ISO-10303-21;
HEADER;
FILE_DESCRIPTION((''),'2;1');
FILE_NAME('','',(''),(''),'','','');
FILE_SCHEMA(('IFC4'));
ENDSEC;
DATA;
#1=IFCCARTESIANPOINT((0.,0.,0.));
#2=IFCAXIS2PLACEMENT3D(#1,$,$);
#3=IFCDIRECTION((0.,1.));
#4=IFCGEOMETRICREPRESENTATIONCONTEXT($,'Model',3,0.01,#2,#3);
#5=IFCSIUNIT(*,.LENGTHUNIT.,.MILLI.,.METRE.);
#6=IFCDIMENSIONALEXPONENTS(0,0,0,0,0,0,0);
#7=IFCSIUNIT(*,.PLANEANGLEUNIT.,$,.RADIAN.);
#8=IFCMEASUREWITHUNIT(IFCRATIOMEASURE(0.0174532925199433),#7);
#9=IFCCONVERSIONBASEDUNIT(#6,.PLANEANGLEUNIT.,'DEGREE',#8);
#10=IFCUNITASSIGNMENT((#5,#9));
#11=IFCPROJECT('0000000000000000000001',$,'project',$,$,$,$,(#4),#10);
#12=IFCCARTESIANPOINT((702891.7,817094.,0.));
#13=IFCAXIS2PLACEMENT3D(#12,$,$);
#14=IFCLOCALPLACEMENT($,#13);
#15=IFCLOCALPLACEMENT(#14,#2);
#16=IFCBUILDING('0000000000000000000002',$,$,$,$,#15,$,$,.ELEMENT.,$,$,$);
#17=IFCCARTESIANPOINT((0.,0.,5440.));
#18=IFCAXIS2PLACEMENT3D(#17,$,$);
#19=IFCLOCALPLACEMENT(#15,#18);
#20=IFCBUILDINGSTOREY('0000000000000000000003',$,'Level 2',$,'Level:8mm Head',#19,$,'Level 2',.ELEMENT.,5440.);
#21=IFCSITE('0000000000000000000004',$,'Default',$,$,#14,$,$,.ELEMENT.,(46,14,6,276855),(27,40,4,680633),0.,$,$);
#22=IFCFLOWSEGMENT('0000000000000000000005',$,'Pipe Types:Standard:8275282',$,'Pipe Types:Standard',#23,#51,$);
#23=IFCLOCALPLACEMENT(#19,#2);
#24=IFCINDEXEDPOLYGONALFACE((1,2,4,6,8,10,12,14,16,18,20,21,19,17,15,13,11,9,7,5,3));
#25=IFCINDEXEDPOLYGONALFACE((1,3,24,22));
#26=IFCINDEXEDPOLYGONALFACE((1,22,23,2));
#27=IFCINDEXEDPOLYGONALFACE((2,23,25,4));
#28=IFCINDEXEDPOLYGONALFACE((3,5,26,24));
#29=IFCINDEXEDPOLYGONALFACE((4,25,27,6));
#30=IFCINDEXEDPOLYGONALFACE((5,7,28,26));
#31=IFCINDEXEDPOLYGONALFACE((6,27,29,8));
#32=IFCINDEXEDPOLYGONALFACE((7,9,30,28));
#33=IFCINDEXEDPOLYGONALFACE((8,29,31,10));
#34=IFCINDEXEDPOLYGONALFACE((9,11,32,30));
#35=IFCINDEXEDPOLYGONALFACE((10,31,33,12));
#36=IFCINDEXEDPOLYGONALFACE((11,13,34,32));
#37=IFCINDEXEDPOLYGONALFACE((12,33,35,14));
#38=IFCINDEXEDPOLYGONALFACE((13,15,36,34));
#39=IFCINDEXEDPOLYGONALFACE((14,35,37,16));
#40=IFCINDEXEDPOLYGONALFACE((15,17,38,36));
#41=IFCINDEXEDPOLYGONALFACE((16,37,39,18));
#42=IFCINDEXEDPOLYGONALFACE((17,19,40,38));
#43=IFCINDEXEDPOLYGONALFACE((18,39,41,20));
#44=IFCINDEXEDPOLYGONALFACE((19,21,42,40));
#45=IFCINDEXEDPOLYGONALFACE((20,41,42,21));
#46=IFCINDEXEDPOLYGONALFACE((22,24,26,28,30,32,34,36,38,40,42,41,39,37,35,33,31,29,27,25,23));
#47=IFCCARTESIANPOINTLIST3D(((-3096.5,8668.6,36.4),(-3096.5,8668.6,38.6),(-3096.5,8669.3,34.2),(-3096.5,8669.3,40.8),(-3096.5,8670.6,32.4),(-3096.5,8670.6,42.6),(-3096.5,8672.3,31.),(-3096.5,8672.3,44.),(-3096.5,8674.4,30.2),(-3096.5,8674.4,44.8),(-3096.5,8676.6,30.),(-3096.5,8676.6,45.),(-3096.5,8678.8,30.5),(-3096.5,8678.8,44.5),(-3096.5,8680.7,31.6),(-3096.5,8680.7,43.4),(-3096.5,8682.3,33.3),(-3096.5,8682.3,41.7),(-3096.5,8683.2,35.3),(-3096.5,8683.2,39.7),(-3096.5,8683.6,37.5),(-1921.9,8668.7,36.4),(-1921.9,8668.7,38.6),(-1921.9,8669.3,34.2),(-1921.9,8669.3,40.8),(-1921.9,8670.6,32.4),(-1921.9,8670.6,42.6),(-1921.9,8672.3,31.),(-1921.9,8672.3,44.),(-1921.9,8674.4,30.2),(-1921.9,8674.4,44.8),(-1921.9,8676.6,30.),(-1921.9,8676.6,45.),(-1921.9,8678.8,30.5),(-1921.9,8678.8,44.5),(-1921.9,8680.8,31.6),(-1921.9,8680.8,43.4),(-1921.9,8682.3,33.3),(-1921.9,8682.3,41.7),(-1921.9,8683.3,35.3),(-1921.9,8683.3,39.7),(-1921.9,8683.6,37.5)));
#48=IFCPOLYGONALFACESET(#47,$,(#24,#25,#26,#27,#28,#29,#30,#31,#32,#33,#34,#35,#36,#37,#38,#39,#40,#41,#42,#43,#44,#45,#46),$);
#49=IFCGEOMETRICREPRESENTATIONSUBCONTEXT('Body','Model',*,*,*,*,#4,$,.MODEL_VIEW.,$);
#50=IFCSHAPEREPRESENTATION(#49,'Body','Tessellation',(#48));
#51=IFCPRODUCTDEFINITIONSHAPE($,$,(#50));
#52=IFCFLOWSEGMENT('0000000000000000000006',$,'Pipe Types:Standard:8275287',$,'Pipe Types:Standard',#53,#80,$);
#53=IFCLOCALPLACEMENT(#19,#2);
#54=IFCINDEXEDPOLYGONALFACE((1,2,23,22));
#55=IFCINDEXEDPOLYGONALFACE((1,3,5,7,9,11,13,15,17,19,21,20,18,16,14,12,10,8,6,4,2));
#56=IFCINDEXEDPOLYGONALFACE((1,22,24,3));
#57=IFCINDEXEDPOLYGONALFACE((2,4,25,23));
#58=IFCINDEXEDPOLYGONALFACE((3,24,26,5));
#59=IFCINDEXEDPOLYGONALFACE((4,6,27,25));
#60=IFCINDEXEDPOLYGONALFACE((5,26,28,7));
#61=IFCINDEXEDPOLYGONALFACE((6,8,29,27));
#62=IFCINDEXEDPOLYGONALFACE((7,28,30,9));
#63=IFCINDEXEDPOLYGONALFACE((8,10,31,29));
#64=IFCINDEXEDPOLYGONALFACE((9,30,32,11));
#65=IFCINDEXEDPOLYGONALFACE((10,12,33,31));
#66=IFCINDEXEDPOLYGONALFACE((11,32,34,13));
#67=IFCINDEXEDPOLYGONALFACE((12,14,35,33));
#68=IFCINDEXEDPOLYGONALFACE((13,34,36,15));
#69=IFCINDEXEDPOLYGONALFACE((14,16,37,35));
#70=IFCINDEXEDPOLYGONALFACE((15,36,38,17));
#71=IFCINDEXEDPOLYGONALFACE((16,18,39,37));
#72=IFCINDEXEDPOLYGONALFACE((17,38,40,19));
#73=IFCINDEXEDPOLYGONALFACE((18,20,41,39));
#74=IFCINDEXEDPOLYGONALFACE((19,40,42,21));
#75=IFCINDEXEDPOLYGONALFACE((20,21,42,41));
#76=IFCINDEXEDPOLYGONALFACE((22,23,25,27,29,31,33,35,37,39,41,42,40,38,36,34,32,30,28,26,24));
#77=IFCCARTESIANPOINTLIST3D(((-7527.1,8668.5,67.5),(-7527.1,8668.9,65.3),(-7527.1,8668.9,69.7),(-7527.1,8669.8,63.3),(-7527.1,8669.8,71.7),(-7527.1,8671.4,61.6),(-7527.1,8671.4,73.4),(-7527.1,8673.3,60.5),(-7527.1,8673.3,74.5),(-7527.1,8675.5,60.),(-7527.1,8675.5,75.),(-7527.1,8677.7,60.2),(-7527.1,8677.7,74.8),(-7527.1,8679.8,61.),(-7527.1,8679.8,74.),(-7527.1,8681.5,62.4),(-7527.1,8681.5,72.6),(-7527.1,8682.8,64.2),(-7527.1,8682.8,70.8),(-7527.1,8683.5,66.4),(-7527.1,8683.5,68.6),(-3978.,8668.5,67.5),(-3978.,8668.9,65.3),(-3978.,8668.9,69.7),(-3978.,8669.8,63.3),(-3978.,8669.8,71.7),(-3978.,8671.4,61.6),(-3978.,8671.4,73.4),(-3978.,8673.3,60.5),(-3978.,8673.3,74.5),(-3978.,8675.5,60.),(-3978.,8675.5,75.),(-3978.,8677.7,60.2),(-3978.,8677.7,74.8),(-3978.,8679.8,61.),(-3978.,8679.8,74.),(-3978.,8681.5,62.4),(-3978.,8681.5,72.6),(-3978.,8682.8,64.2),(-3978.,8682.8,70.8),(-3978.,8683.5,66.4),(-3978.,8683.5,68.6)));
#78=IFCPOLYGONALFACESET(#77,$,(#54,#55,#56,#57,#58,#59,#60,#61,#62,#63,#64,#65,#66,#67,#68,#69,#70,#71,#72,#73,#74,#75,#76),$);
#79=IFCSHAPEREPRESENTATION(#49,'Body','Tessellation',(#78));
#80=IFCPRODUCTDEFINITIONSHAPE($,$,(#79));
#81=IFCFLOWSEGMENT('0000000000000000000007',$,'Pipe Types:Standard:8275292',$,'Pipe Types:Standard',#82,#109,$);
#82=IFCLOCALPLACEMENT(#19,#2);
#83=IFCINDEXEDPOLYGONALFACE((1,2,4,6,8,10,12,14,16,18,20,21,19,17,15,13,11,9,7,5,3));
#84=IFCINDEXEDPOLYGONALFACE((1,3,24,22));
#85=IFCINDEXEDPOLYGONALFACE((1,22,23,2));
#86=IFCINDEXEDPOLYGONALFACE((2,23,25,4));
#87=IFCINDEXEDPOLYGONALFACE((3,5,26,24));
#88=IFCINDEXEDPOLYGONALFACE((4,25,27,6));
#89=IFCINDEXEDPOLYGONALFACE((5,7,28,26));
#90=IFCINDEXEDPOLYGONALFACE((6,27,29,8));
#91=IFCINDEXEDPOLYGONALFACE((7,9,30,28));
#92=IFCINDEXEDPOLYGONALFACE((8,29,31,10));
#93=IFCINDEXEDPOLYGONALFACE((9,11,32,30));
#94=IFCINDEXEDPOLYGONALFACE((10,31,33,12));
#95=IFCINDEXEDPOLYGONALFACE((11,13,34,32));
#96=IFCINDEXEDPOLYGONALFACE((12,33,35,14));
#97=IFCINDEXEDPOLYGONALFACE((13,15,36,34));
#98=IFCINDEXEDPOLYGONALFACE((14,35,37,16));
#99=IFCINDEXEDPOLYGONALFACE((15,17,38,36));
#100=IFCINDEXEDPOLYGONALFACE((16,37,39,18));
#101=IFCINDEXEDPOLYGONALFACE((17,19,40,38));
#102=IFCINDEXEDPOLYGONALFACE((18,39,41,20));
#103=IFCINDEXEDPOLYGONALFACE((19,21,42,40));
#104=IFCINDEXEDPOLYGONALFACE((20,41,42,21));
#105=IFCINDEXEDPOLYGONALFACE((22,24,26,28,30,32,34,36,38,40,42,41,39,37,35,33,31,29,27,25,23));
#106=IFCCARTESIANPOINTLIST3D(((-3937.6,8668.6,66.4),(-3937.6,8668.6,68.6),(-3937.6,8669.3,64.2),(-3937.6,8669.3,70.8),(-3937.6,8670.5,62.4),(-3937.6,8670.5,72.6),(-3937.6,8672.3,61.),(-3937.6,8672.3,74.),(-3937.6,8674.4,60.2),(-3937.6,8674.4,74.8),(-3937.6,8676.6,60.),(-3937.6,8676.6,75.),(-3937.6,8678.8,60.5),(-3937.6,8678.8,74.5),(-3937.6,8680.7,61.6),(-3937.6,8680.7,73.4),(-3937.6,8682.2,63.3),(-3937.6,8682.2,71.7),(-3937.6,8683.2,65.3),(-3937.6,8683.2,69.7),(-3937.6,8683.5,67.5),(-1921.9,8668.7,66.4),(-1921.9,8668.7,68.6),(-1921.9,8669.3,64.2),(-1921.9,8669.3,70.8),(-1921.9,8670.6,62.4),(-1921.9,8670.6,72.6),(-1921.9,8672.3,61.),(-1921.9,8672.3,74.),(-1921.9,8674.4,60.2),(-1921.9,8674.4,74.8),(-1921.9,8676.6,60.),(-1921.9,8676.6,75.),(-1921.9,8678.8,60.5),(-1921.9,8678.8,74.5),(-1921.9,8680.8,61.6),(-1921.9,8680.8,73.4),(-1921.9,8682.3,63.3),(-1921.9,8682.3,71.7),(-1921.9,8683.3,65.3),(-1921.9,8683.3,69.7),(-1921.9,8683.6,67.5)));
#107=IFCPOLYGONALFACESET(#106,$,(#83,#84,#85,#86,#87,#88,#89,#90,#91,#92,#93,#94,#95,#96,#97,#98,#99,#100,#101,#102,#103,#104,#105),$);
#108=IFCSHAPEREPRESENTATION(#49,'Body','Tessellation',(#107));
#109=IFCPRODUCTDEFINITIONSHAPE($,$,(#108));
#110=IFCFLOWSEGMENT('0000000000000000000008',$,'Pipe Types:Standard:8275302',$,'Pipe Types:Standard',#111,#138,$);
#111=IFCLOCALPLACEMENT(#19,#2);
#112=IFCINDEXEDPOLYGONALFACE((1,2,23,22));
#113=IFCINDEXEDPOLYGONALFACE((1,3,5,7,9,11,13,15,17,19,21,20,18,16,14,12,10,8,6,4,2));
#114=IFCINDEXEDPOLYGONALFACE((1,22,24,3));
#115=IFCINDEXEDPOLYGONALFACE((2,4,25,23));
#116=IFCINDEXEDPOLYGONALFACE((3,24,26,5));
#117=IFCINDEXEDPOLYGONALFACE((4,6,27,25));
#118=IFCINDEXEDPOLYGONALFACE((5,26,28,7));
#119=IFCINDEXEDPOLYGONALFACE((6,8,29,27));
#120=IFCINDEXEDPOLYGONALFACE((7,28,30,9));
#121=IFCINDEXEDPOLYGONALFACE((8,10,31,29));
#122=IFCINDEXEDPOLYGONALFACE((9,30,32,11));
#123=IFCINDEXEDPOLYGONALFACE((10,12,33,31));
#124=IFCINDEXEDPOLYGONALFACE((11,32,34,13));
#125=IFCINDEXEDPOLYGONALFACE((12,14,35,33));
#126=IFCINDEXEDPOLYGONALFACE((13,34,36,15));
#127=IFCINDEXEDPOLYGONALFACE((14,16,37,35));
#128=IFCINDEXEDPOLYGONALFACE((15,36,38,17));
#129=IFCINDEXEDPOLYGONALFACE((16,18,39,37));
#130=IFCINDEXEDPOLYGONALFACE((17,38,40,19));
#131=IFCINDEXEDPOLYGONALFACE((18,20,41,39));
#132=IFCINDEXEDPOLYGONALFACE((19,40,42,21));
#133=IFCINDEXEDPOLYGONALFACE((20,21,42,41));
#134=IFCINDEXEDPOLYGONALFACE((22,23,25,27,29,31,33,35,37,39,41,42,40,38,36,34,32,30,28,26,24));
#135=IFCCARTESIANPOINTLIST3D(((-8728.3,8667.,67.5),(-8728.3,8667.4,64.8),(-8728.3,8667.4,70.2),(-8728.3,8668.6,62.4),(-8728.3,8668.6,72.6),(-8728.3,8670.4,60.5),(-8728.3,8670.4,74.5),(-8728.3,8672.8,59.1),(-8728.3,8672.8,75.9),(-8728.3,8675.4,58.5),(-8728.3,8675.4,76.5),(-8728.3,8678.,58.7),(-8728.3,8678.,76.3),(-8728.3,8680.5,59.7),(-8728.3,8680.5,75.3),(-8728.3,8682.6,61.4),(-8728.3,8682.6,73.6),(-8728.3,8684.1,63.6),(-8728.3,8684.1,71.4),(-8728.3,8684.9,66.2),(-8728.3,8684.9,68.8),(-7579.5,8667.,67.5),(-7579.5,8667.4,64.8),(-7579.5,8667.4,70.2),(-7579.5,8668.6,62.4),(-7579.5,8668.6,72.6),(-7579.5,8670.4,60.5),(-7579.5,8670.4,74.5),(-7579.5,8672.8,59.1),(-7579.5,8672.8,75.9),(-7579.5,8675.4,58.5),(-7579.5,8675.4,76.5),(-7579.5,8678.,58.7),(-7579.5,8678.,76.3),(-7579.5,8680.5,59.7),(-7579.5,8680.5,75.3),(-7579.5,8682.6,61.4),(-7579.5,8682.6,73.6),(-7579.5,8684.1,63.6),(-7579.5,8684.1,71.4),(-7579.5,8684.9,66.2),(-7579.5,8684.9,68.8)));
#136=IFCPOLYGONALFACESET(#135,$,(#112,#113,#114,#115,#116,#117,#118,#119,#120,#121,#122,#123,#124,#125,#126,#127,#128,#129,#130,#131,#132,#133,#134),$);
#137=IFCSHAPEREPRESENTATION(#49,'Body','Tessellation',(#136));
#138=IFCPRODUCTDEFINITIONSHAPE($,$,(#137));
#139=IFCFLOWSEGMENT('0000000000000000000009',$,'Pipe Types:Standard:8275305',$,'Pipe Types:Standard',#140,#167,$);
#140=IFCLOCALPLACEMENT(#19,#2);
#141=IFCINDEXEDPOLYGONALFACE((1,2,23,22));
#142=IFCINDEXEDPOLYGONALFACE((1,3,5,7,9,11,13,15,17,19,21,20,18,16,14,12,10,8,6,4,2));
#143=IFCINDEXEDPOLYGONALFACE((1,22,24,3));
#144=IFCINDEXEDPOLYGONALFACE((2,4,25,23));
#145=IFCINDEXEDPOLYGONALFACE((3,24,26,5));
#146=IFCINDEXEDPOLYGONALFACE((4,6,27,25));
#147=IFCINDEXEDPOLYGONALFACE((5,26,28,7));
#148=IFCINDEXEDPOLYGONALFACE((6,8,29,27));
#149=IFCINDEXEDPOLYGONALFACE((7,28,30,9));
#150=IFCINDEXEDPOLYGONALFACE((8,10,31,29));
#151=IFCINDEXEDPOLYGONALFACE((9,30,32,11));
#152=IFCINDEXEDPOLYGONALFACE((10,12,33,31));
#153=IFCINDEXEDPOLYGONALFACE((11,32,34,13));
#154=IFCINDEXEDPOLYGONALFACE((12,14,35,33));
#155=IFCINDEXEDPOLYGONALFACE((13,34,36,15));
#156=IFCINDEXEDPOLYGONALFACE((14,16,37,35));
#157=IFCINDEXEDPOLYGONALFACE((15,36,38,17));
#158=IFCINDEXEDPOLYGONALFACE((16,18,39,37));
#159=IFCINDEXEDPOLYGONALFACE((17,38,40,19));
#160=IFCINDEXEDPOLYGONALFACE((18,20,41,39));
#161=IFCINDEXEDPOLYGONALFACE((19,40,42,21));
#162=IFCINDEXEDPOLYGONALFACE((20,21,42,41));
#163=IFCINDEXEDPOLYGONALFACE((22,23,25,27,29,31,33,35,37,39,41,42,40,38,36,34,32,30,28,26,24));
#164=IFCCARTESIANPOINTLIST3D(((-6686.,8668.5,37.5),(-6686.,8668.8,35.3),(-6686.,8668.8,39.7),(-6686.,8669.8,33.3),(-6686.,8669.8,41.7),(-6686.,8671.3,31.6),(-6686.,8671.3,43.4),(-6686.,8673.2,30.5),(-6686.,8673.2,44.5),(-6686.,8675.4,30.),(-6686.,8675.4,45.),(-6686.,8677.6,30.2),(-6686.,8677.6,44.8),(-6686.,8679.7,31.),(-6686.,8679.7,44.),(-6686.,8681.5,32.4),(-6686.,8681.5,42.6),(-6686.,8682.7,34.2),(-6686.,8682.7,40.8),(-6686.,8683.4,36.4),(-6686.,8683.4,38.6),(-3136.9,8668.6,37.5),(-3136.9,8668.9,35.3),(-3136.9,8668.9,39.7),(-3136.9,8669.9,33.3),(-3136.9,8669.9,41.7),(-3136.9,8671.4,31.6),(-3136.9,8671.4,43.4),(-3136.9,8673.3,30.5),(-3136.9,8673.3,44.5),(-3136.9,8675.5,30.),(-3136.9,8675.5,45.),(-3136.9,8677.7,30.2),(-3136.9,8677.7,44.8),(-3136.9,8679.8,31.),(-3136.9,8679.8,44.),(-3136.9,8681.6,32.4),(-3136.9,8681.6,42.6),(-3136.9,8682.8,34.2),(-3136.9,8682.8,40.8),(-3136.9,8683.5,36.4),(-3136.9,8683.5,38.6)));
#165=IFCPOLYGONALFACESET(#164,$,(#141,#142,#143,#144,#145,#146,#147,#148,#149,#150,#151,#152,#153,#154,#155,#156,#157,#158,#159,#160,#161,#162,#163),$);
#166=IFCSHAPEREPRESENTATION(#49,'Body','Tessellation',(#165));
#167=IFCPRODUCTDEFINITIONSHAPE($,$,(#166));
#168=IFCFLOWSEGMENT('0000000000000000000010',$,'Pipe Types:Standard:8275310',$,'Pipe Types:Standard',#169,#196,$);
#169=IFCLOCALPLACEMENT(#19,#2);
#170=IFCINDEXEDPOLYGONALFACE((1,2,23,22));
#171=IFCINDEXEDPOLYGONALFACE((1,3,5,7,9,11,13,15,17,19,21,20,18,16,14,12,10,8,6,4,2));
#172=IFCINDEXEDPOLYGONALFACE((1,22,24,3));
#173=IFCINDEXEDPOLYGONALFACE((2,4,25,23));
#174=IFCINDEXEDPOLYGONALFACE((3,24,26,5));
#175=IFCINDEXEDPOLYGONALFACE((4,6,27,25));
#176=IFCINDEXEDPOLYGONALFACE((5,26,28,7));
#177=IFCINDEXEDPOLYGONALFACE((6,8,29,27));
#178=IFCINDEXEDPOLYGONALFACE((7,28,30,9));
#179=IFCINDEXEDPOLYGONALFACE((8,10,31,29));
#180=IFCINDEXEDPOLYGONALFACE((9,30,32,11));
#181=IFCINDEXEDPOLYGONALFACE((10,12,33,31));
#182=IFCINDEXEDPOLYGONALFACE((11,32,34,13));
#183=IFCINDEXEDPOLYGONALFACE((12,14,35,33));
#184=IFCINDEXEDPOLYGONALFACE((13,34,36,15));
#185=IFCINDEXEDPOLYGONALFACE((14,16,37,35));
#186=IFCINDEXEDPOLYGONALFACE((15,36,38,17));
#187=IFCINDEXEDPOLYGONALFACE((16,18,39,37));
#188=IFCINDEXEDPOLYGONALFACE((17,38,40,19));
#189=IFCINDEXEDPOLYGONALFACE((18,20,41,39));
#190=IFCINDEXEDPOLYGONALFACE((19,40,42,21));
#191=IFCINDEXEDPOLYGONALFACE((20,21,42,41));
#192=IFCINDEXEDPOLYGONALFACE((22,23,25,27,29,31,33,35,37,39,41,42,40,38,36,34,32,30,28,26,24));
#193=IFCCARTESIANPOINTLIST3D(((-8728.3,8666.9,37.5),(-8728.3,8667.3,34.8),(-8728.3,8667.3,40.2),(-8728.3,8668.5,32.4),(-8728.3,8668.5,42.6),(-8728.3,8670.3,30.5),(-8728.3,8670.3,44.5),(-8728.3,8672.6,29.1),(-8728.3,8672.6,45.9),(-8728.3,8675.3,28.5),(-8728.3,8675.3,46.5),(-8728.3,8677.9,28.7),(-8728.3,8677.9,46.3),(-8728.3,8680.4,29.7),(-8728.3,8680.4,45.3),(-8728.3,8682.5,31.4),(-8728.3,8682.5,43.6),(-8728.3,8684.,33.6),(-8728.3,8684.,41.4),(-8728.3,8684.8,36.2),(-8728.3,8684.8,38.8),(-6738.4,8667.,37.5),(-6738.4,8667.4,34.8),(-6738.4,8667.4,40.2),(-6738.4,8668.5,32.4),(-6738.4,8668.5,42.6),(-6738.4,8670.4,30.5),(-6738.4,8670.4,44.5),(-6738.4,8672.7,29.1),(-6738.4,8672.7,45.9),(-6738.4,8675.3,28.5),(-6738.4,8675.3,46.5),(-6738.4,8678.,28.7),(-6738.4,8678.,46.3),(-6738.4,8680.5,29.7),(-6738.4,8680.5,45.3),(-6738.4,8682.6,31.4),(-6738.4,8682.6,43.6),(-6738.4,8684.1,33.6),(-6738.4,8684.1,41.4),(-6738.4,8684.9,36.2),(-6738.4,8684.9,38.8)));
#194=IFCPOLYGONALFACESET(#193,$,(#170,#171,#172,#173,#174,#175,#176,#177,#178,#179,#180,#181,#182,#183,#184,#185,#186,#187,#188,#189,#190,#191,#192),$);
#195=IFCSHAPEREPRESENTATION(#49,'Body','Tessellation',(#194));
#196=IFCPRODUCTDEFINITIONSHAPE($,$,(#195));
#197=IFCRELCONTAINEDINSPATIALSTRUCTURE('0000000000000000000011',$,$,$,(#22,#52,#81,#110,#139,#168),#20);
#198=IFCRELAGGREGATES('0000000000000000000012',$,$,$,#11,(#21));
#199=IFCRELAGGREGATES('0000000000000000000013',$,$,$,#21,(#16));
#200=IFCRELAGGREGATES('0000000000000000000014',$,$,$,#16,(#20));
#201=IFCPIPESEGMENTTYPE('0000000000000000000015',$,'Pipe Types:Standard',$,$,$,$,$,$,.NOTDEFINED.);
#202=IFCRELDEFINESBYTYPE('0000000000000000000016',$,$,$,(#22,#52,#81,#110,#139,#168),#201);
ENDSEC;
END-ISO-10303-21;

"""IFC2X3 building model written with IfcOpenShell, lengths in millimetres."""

from ifc_helpers import new_model, entity, si_unit, converted_unit, direction, frame, origin, origin_2d_with_axis, place, context, subcontext, project, spatial, circle, extrude, type_object, element, save


model = new_model("IFC2X3")

# Units and contexts
model_context = context("Model", 3, precision=0.01, world=origin(), true_north=direction((0.0, 1.0)))
body_context = subcontext(model_context, "Body", "Model", "MODEL_VIEW")
ifc_project = project(units=[si_unit("LENGTHUNIT", "METRE", prefix="MILLI"), converted_unit("PLANEANGLEUNIT", "DEGREE", entity("IfcRatioMeasure", 0.0174532925199433), si_unit("PLANEANGLEUNIT", "RADIAN"), dimensions=[0, 0, 0, 0, 0, 0, 0])], contexts=[model_context])

# Site, building, storey
site_placement = place(None, frame((702891.7, 817094.0, 0.0)))
site = spatial("IfcSite", under=ifc_project, at=site_placement, Name="Default", CompositionType="ELEMENT", RefLatitude=(46, 14, 6, 276855), RefLongitude=(27, 40, 4, 680633), RefElevation=0.0)
building_placement = place(site_placement, origin())
building = spatial("IfcBuilding", under=site, at=building_placement, CompositionType="ELEMENT")
storey_placement = place(building_placement, frame((0.0, 0.0, 5440.0)))
storey = spatial("IfcBuildingStorey", under=building, at=storey_placement, Name="Level 2", ObjectType="Level:8mm Head", LongName="Level 2", CompositionType="ELEMENT", Elevation=5440.0)

# Flow segments
pipe_segment_type = type_object("IfcPipeSegmentType", Name="Pipe Types:Standard", PredefinedType="NOTDEFINED")
flow_segment_1_placement = place(storey_placement, origin())
element("IfcFlowSegment", 1, at=flow_segment_1_placement, inside=storey, type_object=pipe_segment_type, Name="Pipe Types:Standard:8275282", ObjectType="Pipe Types:Standard", context=body_context, shape_type="SweptSolid", body=[
    extrude(circle(Radius=7.5, at=origin_2d_with_axis()), frame((-3096.5, 8676.1, 37.5), z_axis=(1.0, 0.000024, 0.0), x_axis=(-0.000024, 1.0, 0.0)), (0.0, 0.0, 1.0), 1174.6),
])
flow_segment_2_placement = place(storey_placement, origin())
element("IfcFlowSegment", 2, at=flow_segment_2_placement, inside=storey, type_object=pipe_segment_type, Name="Pipe Types:Standard:8275287", ObjectType="Pipe Types:Standard", context=body_context, shape_type="SweptSolid", body=[
    extrude(circle(Radius=7.5, at=origin_2d_with_axis()), frame((-7527.1, 8676.0, 67.5), z_axis=(1.0, 0.0, 0.0), x_axis=(0.0, -1.0, 0.0)), (0.0, 0.0, 1.0), 3549.1),
])
flow_segment_3_placement = place(storey_placement, origin())
element("IfcFlowSegment", 3, at=flow_segment_3_placement, inside=storey, type_object=pipe_segment_type, Name="Pipe Types:Standard:8275292", ObjectType="Pipe Types:Standard", context=body_context, shape_type="SweptSolid", body=[
    extrude(circle(Radius=7.5, at=origin_2d_with_axis()), frame((-3937.6, 8676.0, 67.5), z_axis=(1.0, 0.000024, 0.0), x_axis=(-0.000024, 1.0, 0.0)), (0.0, 0.0, 1.0), 2015.7),
])
flow_segment_4_placement = place(storey_placement, origin())
element("IfcFlowSegment", 4, at=flow_segment_4_placement, inside=storey, type_object=pipe_segment_type, Name="Pipe Types:Standard:8275302", ObjectType="Pipe Types:Standard", context=body_context, shape_type="SweptSolid", body=[
    extrude(circle(Radius=9.0, at=origin_2d_with_axis()), frame((-8728.3, 8676.0, 67.5), z_axis=(1.0, 0.0, 0.0), x_axis=(0.0, -1.0, 0.0)), (0.0, 0.0, 1.0), 1148.8),
])
flow_segment_5_placement = place(storey_placement, origin())
element("IfcFlowSegment", 5, at=flow_segment_5_placement, inside=storey, type_object=pipe_segment_type, Name="Pipe Types:Standard:8275305", ObjectType="Pipe Types:Standard", context=body_context, shape_type="SweptSolid", body=[
    extrude(circle(Radius=7.5, at=origin_2d_with_axis()), frame((-6686.0, 8676.0, 37.5), z_axis=(1.0, 0.000024, 0.0), x_axis=(0.000024, -1.0, 0.0)), (0.0, 0.0, 1.0), 3549.1),
])
flow_segment_6_placement = place(storey_placement, origin())
element("IfcFlowSegment", 6, at=flow_segment_6_placement, inside=storey, type_object=pipe_segment_type, Name="Pipe Types:Standard:8275310", ObjectType="Pipe Types:Standard", context=body_context, shape_type="SweptSolid", body=[
    extrude(circle(Radius=9.0, at=origin_2d_with_axis()), frame((-8728.3, 8675.9, 37.5), z_axis=(1.0, 0.000024, 0.0), x_axis=(0.000024, -1.0, 0.0)), (0.0, 0.0, 1.0), 1990.0),
])

save(model, "model.ifc")
